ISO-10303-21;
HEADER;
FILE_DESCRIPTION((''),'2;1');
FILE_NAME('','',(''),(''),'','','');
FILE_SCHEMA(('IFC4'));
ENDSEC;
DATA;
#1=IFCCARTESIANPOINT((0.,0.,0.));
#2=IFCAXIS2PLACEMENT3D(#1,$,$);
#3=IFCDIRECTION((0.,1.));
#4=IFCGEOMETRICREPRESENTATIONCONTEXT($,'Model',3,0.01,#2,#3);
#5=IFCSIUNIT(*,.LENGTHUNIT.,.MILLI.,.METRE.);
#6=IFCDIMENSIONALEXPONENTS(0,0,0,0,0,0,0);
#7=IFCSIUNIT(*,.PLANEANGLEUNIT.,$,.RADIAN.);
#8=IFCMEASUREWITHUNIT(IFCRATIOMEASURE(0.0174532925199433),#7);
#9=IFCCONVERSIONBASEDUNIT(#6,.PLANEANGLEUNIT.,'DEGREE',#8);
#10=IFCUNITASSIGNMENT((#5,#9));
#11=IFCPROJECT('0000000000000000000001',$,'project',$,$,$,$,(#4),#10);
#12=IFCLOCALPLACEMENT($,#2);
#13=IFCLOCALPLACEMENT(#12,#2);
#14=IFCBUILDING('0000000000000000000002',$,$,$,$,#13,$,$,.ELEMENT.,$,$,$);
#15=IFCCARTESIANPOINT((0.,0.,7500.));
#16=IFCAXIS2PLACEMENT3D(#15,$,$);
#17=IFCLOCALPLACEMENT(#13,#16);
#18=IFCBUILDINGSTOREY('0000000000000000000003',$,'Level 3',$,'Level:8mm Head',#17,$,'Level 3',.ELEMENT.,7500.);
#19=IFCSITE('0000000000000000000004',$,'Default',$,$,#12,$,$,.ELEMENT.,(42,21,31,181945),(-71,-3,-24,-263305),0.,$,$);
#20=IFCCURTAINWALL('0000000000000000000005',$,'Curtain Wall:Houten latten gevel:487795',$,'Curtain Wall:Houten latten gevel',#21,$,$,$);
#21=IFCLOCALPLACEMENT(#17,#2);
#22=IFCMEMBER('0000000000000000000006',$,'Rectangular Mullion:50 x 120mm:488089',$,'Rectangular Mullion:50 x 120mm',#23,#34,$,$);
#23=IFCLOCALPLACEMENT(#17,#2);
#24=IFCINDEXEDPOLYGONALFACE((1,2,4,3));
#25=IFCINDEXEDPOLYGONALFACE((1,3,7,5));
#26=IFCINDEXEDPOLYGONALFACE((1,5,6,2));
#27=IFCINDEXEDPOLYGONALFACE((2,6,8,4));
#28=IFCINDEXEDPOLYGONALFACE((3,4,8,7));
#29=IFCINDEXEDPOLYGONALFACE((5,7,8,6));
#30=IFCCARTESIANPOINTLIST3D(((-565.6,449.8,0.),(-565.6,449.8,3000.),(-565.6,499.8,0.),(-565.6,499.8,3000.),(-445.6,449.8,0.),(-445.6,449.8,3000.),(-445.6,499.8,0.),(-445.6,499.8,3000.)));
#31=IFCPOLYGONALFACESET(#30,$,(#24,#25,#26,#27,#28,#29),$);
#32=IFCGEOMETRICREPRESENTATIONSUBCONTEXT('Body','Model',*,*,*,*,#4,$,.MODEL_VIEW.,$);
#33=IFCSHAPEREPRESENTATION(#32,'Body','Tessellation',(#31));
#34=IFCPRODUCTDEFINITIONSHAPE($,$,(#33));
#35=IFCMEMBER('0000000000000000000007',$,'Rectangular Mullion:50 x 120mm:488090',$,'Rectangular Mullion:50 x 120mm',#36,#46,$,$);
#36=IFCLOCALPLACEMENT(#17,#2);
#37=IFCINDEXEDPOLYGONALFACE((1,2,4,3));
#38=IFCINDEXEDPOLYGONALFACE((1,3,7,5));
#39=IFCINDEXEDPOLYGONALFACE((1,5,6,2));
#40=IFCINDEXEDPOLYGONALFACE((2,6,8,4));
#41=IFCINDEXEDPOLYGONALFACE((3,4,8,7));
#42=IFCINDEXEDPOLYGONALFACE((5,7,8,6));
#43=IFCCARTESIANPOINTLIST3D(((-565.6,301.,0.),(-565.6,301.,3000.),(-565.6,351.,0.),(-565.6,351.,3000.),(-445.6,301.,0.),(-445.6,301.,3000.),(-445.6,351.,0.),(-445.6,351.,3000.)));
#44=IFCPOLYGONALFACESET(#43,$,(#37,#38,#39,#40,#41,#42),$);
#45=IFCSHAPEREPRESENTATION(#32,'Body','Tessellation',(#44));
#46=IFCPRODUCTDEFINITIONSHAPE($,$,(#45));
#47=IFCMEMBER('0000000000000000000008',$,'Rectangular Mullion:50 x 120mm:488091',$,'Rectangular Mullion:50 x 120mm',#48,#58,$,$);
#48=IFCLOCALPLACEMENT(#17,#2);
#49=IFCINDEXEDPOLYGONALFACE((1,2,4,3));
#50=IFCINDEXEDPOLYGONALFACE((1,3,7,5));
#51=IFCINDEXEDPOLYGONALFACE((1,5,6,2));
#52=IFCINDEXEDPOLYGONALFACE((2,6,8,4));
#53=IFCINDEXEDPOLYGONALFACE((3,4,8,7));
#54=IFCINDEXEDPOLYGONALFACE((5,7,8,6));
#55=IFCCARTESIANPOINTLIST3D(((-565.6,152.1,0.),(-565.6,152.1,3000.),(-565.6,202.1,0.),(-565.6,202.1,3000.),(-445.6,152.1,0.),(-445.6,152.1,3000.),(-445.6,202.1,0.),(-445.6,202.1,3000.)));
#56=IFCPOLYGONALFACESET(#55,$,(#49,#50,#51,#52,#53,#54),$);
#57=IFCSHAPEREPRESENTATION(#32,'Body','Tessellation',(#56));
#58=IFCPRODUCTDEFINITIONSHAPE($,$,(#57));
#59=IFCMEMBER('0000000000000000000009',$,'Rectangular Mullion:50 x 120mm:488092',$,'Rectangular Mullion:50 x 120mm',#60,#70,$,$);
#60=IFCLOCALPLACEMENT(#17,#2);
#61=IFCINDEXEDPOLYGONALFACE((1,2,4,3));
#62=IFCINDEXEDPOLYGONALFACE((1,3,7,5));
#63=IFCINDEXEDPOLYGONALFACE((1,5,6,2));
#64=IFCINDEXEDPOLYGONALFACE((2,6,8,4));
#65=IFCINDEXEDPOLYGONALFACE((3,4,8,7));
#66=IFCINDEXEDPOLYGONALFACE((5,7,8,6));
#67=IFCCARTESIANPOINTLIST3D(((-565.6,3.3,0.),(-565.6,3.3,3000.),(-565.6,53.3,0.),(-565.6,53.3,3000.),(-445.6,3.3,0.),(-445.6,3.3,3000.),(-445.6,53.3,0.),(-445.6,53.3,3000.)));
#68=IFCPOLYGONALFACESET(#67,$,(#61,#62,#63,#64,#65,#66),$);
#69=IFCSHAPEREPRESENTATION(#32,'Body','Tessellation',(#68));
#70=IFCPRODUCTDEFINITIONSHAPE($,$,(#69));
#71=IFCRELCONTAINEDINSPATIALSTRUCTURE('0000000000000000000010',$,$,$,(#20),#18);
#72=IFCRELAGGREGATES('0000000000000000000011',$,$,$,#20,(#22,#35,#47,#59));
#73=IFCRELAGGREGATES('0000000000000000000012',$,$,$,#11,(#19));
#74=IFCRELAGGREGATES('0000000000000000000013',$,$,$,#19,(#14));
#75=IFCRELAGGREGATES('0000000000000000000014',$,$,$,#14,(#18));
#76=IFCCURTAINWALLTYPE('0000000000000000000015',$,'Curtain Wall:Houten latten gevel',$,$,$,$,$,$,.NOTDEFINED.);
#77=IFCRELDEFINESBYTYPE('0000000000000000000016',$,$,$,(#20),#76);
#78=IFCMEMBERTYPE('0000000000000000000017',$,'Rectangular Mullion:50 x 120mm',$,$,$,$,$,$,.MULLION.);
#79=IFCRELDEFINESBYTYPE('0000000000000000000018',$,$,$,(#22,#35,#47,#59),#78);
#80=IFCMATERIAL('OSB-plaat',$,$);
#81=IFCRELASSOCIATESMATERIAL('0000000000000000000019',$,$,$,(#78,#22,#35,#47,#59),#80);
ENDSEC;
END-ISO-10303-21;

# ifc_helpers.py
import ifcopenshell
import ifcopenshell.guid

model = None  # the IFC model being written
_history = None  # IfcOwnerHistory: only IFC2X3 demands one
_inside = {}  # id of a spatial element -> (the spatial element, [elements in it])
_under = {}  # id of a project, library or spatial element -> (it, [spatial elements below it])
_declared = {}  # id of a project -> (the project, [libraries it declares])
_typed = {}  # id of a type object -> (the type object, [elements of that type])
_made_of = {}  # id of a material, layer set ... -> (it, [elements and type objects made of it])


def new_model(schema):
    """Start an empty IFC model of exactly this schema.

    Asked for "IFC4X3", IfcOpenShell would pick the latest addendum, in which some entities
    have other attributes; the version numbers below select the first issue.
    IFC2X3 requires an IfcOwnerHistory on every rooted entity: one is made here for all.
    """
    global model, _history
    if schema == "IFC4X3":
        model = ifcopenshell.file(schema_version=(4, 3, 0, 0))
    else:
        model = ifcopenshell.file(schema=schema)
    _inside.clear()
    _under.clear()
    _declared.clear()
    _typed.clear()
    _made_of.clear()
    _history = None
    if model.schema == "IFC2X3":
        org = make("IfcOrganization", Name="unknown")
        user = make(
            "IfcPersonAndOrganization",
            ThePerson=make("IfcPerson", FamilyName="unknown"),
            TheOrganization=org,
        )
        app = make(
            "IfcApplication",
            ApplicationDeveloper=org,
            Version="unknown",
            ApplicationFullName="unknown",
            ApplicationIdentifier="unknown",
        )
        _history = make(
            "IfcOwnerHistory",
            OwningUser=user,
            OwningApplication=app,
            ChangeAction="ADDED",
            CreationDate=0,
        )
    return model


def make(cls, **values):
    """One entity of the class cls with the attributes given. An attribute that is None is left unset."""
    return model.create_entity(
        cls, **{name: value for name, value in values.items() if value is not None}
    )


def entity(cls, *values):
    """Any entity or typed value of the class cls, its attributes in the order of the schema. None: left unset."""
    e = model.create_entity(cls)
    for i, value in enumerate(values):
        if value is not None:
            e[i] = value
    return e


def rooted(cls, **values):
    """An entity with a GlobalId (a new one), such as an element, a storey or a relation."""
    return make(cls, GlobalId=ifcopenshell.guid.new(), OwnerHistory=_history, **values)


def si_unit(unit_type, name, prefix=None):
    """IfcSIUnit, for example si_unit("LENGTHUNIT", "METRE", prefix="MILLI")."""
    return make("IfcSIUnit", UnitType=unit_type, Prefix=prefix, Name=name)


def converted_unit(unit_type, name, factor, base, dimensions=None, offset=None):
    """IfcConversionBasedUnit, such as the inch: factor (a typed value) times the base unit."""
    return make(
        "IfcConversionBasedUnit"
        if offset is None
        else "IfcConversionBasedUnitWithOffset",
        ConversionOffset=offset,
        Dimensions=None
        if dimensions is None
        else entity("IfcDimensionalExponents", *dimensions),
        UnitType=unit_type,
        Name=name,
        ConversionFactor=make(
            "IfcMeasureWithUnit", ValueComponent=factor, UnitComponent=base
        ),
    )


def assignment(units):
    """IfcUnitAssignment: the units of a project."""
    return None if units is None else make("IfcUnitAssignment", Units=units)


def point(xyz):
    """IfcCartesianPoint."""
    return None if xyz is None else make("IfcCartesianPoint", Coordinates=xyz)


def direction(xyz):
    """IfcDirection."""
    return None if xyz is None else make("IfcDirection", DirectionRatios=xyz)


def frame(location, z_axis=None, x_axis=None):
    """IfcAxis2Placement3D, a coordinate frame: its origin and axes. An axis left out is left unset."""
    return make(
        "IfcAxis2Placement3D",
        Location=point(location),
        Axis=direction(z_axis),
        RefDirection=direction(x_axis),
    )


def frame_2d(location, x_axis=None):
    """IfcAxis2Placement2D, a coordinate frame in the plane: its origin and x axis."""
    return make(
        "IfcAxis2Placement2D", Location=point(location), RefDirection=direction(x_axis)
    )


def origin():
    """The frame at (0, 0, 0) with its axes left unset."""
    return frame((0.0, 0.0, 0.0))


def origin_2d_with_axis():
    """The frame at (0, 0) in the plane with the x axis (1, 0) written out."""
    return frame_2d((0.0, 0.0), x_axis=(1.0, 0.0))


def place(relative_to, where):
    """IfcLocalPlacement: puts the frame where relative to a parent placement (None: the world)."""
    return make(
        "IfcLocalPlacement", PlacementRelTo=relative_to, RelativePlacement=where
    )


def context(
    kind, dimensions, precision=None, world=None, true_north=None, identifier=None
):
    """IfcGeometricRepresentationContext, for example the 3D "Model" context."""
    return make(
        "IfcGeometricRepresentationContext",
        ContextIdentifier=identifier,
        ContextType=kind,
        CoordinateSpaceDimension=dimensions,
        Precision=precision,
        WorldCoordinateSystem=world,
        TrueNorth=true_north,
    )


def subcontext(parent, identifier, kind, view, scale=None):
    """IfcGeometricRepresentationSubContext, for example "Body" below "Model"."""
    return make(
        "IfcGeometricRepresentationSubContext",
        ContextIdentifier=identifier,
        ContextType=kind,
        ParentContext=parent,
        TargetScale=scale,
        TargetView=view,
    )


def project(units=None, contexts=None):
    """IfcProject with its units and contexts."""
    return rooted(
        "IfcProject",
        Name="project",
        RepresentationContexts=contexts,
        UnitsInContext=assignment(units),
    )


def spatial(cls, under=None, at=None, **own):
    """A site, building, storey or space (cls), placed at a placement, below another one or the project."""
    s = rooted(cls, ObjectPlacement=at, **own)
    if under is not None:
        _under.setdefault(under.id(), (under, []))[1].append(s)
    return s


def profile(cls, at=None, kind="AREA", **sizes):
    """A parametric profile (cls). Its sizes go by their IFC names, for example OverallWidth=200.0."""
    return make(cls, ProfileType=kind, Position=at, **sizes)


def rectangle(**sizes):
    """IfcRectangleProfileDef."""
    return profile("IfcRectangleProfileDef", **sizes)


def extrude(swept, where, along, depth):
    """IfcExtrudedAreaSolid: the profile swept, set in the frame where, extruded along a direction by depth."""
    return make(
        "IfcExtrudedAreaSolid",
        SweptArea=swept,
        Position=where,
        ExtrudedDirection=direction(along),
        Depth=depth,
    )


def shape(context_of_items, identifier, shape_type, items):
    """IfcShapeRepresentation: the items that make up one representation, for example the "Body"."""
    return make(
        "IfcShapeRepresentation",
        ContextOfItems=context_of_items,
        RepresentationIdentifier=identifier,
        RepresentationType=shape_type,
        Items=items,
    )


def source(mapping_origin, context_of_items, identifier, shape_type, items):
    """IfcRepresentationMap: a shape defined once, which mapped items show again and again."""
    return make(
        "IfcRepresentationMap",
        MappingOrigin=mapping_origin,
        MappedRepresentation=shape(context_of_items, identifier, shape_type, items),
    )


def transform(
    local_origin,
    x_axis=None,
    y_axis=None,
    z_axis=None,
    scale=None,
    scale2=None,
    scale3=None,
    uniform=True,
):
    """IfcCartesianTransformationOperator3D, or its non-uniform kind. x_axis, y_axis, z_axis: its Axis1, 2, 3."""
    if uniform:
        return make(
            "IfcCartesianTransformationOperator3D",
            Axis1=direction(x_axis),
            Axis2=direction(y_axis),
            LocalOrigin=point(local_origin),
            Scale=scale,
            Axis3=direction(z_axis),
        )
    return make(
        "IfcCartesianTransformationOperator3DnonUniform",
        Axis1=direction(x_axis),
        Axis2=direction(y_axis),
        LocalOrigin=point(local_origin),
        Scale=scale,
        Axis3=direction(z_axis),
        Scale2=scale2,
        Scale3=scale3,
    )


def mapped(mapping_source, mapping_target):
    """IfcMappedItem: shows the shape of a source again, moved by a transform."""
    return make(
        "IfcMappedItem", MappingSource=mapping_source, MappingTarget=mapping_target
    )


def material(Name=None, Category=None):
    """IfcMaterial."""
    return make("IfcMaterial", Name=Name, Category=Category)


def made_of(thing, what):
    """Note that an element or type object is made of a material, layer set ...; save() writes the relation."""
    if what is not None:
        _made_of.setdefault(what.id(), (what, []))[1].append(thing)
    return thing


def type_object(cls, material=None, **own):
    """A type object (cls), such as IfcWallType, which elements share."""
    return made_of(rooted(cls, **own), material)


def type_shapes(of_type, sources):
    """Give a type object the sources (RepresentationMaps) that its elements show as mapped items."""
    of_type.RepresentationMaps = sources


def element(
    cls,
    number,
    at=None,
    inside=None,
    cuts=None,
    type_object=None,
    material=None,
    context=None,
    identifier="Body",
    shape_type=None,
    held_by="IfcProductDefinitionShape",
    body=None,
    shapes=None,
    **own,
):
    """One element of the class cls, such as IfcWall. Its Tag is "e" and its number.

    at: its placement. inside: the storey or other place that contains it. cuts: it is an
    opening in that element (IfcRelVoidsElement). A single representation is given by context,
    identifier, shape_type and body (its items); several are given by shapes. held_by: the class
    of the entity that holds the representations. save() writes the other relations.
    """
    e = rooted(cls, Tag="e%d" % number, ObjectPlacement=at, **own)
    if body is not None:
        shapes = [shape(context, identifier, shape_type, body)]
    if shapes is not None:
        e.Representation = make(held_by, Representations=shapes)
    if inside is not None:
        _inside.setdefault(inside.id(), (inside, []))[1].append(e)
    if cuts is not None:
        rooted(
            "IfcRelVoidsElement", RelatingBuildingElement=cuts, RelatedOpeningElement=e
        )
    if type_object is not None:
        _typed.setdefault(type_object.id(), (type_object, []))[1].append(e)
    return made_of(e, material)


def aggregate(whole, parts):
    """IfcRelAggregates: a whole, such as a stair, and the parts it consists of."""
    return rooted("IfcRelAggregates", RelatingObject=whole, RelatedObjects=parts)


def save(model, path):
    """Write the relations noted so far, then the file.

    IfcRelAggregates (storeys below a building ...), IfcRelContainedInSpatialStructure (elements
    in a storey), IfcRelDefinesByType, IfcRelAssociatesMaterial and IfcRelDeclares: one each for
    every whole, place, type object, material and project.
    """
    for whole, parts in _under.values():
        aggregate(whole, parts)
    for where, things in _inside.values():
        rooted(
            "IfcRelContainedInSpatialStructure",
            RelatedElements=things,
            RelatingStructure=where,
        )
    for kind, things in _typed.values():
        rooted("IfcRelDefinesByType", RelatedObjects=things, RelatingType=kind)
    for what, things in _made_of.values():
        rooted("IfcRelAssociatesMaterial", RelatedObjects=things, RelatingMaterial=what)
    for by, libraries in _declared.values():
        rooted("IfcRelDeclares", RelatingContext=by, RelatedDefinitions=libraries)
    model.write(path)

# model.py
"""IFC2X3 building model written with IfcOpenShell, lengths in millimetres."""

from ifc_helpers import new_model, entity, si_unit, converted_unit, direction, frame, origin, origin_2d_with_axis, place, context, subcontext, project, spatial, rectangle, extrude, source, transform, mapped, material, type_object, type_shapes, element, aggregate, save


model = new_model("IFC2X3")

# Units and contexts
model_context = context("Model", 3, precision=0.01, world=origin(), true_north=direction((0.0, 1.0)))
body_context = subcontext(model_context, "Body", "Model", "MODEL_VIEW")
ifc_project = project(units=[si_unit("LENGTHUNIT", "METRE", prefix="MILLI"), converted_unit("PLANEANGLEUNIT", "DEGREE", entity("IfcRatioMeasure", 0.0174532925199433), si_unit("PLANEANGLEUNIT", "RADIAN"), dimensions=[0, 0, 0, 0, 0, 0, 0])], contexts=[model_context])

# Site, building, storey
site_placement = place(None, frame((0.0, 0.0, 0.0)))
site = spatial("IfcSite", under=ifc_project, at=site_placement, Name="Default", CompositionType="ELEMENT", RefLatitude=(42, 21, 31, 181945), RefLongitude=(-71, -3, -24, -263305), RefElevation=0.0)
building_placement = place(site_placement, origin())
building = spatial("IfcBuilding", under=site, at=building_placement, CompositionType="ELEMENT")
storey_placement = place(building_placement, frame((0.0, 0.0, 7500.0)))
storey = spatial("IfcBuildingStorey", under=building, at=storey_placement, Name="Level 3", ObjectType="Level:8mm Head", LongName="Level 3", CompositionType="ELEMENT", Elevation=7500.0)

# Curtain wall, members
curtain_wall_type = type_object("IfcCurtainWallType", Name="Curtain Wall:Houten latten gevel", PredefinedType="NOTDEFINED")
curtain_wall_placement = place(storey_placement, frame((0.0, 0.0, -7500.0)))
curtain_wall = element("IfcCurtainWall", 1, at=curtain_wall_placement, inside=storey, type_object=curtain_wall_type, Name="Curtain Wall:Houten latten gevel:487795", ObjectType="Curtain Wall:Houten latten gevel")
ifc_material = material(Name="OSB-plaat")
member_type_1 = type_object("IfcMemberType", Name="Rectangular Mullion:50 x 120mm", PredefinedType="MULLION", material=ifc_material)
shared_shape = source(origin(), body_context, "Body", "SweptSolid", [
    extrude(rectangle(XDim=120.0, YDim=50.0, at=origin_2d_with_axis()), frame((0.0, 0.0, -3000.0), z_axis=(0.0, 0.0, 1.0), x_axis=(0.0, -1.0, 0.0)), (0.0, 0.0, 1.0), 3000.0),
])
type_shapes(member_type_1, [shared_shape])
member_1_placement = place(storey_placement, frame((-505.6, 474.8, 0.0), z_axis=(0.0, 0.0, -1.0), x_axis=(0.0, -1.0, 0.0)))
member_1 = element("IfcMember", 2, at=member_1_placement, type_object=member_type_1, material=ifc_material, Name="Rectangular Mullion:50 x 120mm:488089", ObjectType="Rectangular Mullion:50 x 120mm", context=body_context, shape_type="MappedRepresentation", body=[
    mapped(shared_shape, transform((0.0, 0.0, 0.0), scale=1.0)),
])
member_2_placement = place(storey_placement, frame((-505.6, 326.0, 0.0), z_axis=(0.0, 0.0, -1.0), x_axis=(0.0, -1.0, 0.0)))
member_2 = element("IfcMember", 3, at=member_2_placement, type_object=member_type_1, material=ifc_material, Name="Rectangular Mullion:50 x 120mm:488090", ObjectType="Rectangular Mullion:50 x 120mm", context=body_context, shape_type="MappedRepresentation", body=[
    mapped(shared_shape, transform((0.0, 0.0, 0.0), scale=1.0)),
])
member_3_placement = place(storey_placement, frame((-505.6, 177.1, 0.0), z_axis=(0.0, 0.0, -1.0), x_axis=(0.0, -1.0, 0.0)))
member_3 = element("IfcMember", 4, at=member_3_placement, type_object=member_type_1, material=ifc_material, Name="Rectangular Mullion:50 x 120mm:488091", ObjectType="Rectangular Mullion:50 x 120mm", context=body_context, shape_type="MappedRepresentation", body=[
    mapped(shared_shape, transform((0.0, 0.0, 0.0), scale=1.0)),
])
member_4_placement = place(storey_placement, frame((-505.6, 28.3, 0.0), z_axis=(0.0, 0.0, -1.0), x_axis=(0.0, -1.0, 0.0)))
member_4 = element("IfcMember", 5, at=member_4_placement, type_object=member_type_1, material=ifc_material, Name="Rectangular Mullion:50 x 120mm:488092", ObjectType="Rectangular Mullion:50 x 120mm", context=body_context, shape_type="MappedRepresentation", body=[
    mapped(shared_shape, transform((0.0, 0.0, 0.0), scale=1.0)),
])
aggregate(curtain_wall, [member_1, member_2, member_3, member_4])

save(model, "model.ifc")
